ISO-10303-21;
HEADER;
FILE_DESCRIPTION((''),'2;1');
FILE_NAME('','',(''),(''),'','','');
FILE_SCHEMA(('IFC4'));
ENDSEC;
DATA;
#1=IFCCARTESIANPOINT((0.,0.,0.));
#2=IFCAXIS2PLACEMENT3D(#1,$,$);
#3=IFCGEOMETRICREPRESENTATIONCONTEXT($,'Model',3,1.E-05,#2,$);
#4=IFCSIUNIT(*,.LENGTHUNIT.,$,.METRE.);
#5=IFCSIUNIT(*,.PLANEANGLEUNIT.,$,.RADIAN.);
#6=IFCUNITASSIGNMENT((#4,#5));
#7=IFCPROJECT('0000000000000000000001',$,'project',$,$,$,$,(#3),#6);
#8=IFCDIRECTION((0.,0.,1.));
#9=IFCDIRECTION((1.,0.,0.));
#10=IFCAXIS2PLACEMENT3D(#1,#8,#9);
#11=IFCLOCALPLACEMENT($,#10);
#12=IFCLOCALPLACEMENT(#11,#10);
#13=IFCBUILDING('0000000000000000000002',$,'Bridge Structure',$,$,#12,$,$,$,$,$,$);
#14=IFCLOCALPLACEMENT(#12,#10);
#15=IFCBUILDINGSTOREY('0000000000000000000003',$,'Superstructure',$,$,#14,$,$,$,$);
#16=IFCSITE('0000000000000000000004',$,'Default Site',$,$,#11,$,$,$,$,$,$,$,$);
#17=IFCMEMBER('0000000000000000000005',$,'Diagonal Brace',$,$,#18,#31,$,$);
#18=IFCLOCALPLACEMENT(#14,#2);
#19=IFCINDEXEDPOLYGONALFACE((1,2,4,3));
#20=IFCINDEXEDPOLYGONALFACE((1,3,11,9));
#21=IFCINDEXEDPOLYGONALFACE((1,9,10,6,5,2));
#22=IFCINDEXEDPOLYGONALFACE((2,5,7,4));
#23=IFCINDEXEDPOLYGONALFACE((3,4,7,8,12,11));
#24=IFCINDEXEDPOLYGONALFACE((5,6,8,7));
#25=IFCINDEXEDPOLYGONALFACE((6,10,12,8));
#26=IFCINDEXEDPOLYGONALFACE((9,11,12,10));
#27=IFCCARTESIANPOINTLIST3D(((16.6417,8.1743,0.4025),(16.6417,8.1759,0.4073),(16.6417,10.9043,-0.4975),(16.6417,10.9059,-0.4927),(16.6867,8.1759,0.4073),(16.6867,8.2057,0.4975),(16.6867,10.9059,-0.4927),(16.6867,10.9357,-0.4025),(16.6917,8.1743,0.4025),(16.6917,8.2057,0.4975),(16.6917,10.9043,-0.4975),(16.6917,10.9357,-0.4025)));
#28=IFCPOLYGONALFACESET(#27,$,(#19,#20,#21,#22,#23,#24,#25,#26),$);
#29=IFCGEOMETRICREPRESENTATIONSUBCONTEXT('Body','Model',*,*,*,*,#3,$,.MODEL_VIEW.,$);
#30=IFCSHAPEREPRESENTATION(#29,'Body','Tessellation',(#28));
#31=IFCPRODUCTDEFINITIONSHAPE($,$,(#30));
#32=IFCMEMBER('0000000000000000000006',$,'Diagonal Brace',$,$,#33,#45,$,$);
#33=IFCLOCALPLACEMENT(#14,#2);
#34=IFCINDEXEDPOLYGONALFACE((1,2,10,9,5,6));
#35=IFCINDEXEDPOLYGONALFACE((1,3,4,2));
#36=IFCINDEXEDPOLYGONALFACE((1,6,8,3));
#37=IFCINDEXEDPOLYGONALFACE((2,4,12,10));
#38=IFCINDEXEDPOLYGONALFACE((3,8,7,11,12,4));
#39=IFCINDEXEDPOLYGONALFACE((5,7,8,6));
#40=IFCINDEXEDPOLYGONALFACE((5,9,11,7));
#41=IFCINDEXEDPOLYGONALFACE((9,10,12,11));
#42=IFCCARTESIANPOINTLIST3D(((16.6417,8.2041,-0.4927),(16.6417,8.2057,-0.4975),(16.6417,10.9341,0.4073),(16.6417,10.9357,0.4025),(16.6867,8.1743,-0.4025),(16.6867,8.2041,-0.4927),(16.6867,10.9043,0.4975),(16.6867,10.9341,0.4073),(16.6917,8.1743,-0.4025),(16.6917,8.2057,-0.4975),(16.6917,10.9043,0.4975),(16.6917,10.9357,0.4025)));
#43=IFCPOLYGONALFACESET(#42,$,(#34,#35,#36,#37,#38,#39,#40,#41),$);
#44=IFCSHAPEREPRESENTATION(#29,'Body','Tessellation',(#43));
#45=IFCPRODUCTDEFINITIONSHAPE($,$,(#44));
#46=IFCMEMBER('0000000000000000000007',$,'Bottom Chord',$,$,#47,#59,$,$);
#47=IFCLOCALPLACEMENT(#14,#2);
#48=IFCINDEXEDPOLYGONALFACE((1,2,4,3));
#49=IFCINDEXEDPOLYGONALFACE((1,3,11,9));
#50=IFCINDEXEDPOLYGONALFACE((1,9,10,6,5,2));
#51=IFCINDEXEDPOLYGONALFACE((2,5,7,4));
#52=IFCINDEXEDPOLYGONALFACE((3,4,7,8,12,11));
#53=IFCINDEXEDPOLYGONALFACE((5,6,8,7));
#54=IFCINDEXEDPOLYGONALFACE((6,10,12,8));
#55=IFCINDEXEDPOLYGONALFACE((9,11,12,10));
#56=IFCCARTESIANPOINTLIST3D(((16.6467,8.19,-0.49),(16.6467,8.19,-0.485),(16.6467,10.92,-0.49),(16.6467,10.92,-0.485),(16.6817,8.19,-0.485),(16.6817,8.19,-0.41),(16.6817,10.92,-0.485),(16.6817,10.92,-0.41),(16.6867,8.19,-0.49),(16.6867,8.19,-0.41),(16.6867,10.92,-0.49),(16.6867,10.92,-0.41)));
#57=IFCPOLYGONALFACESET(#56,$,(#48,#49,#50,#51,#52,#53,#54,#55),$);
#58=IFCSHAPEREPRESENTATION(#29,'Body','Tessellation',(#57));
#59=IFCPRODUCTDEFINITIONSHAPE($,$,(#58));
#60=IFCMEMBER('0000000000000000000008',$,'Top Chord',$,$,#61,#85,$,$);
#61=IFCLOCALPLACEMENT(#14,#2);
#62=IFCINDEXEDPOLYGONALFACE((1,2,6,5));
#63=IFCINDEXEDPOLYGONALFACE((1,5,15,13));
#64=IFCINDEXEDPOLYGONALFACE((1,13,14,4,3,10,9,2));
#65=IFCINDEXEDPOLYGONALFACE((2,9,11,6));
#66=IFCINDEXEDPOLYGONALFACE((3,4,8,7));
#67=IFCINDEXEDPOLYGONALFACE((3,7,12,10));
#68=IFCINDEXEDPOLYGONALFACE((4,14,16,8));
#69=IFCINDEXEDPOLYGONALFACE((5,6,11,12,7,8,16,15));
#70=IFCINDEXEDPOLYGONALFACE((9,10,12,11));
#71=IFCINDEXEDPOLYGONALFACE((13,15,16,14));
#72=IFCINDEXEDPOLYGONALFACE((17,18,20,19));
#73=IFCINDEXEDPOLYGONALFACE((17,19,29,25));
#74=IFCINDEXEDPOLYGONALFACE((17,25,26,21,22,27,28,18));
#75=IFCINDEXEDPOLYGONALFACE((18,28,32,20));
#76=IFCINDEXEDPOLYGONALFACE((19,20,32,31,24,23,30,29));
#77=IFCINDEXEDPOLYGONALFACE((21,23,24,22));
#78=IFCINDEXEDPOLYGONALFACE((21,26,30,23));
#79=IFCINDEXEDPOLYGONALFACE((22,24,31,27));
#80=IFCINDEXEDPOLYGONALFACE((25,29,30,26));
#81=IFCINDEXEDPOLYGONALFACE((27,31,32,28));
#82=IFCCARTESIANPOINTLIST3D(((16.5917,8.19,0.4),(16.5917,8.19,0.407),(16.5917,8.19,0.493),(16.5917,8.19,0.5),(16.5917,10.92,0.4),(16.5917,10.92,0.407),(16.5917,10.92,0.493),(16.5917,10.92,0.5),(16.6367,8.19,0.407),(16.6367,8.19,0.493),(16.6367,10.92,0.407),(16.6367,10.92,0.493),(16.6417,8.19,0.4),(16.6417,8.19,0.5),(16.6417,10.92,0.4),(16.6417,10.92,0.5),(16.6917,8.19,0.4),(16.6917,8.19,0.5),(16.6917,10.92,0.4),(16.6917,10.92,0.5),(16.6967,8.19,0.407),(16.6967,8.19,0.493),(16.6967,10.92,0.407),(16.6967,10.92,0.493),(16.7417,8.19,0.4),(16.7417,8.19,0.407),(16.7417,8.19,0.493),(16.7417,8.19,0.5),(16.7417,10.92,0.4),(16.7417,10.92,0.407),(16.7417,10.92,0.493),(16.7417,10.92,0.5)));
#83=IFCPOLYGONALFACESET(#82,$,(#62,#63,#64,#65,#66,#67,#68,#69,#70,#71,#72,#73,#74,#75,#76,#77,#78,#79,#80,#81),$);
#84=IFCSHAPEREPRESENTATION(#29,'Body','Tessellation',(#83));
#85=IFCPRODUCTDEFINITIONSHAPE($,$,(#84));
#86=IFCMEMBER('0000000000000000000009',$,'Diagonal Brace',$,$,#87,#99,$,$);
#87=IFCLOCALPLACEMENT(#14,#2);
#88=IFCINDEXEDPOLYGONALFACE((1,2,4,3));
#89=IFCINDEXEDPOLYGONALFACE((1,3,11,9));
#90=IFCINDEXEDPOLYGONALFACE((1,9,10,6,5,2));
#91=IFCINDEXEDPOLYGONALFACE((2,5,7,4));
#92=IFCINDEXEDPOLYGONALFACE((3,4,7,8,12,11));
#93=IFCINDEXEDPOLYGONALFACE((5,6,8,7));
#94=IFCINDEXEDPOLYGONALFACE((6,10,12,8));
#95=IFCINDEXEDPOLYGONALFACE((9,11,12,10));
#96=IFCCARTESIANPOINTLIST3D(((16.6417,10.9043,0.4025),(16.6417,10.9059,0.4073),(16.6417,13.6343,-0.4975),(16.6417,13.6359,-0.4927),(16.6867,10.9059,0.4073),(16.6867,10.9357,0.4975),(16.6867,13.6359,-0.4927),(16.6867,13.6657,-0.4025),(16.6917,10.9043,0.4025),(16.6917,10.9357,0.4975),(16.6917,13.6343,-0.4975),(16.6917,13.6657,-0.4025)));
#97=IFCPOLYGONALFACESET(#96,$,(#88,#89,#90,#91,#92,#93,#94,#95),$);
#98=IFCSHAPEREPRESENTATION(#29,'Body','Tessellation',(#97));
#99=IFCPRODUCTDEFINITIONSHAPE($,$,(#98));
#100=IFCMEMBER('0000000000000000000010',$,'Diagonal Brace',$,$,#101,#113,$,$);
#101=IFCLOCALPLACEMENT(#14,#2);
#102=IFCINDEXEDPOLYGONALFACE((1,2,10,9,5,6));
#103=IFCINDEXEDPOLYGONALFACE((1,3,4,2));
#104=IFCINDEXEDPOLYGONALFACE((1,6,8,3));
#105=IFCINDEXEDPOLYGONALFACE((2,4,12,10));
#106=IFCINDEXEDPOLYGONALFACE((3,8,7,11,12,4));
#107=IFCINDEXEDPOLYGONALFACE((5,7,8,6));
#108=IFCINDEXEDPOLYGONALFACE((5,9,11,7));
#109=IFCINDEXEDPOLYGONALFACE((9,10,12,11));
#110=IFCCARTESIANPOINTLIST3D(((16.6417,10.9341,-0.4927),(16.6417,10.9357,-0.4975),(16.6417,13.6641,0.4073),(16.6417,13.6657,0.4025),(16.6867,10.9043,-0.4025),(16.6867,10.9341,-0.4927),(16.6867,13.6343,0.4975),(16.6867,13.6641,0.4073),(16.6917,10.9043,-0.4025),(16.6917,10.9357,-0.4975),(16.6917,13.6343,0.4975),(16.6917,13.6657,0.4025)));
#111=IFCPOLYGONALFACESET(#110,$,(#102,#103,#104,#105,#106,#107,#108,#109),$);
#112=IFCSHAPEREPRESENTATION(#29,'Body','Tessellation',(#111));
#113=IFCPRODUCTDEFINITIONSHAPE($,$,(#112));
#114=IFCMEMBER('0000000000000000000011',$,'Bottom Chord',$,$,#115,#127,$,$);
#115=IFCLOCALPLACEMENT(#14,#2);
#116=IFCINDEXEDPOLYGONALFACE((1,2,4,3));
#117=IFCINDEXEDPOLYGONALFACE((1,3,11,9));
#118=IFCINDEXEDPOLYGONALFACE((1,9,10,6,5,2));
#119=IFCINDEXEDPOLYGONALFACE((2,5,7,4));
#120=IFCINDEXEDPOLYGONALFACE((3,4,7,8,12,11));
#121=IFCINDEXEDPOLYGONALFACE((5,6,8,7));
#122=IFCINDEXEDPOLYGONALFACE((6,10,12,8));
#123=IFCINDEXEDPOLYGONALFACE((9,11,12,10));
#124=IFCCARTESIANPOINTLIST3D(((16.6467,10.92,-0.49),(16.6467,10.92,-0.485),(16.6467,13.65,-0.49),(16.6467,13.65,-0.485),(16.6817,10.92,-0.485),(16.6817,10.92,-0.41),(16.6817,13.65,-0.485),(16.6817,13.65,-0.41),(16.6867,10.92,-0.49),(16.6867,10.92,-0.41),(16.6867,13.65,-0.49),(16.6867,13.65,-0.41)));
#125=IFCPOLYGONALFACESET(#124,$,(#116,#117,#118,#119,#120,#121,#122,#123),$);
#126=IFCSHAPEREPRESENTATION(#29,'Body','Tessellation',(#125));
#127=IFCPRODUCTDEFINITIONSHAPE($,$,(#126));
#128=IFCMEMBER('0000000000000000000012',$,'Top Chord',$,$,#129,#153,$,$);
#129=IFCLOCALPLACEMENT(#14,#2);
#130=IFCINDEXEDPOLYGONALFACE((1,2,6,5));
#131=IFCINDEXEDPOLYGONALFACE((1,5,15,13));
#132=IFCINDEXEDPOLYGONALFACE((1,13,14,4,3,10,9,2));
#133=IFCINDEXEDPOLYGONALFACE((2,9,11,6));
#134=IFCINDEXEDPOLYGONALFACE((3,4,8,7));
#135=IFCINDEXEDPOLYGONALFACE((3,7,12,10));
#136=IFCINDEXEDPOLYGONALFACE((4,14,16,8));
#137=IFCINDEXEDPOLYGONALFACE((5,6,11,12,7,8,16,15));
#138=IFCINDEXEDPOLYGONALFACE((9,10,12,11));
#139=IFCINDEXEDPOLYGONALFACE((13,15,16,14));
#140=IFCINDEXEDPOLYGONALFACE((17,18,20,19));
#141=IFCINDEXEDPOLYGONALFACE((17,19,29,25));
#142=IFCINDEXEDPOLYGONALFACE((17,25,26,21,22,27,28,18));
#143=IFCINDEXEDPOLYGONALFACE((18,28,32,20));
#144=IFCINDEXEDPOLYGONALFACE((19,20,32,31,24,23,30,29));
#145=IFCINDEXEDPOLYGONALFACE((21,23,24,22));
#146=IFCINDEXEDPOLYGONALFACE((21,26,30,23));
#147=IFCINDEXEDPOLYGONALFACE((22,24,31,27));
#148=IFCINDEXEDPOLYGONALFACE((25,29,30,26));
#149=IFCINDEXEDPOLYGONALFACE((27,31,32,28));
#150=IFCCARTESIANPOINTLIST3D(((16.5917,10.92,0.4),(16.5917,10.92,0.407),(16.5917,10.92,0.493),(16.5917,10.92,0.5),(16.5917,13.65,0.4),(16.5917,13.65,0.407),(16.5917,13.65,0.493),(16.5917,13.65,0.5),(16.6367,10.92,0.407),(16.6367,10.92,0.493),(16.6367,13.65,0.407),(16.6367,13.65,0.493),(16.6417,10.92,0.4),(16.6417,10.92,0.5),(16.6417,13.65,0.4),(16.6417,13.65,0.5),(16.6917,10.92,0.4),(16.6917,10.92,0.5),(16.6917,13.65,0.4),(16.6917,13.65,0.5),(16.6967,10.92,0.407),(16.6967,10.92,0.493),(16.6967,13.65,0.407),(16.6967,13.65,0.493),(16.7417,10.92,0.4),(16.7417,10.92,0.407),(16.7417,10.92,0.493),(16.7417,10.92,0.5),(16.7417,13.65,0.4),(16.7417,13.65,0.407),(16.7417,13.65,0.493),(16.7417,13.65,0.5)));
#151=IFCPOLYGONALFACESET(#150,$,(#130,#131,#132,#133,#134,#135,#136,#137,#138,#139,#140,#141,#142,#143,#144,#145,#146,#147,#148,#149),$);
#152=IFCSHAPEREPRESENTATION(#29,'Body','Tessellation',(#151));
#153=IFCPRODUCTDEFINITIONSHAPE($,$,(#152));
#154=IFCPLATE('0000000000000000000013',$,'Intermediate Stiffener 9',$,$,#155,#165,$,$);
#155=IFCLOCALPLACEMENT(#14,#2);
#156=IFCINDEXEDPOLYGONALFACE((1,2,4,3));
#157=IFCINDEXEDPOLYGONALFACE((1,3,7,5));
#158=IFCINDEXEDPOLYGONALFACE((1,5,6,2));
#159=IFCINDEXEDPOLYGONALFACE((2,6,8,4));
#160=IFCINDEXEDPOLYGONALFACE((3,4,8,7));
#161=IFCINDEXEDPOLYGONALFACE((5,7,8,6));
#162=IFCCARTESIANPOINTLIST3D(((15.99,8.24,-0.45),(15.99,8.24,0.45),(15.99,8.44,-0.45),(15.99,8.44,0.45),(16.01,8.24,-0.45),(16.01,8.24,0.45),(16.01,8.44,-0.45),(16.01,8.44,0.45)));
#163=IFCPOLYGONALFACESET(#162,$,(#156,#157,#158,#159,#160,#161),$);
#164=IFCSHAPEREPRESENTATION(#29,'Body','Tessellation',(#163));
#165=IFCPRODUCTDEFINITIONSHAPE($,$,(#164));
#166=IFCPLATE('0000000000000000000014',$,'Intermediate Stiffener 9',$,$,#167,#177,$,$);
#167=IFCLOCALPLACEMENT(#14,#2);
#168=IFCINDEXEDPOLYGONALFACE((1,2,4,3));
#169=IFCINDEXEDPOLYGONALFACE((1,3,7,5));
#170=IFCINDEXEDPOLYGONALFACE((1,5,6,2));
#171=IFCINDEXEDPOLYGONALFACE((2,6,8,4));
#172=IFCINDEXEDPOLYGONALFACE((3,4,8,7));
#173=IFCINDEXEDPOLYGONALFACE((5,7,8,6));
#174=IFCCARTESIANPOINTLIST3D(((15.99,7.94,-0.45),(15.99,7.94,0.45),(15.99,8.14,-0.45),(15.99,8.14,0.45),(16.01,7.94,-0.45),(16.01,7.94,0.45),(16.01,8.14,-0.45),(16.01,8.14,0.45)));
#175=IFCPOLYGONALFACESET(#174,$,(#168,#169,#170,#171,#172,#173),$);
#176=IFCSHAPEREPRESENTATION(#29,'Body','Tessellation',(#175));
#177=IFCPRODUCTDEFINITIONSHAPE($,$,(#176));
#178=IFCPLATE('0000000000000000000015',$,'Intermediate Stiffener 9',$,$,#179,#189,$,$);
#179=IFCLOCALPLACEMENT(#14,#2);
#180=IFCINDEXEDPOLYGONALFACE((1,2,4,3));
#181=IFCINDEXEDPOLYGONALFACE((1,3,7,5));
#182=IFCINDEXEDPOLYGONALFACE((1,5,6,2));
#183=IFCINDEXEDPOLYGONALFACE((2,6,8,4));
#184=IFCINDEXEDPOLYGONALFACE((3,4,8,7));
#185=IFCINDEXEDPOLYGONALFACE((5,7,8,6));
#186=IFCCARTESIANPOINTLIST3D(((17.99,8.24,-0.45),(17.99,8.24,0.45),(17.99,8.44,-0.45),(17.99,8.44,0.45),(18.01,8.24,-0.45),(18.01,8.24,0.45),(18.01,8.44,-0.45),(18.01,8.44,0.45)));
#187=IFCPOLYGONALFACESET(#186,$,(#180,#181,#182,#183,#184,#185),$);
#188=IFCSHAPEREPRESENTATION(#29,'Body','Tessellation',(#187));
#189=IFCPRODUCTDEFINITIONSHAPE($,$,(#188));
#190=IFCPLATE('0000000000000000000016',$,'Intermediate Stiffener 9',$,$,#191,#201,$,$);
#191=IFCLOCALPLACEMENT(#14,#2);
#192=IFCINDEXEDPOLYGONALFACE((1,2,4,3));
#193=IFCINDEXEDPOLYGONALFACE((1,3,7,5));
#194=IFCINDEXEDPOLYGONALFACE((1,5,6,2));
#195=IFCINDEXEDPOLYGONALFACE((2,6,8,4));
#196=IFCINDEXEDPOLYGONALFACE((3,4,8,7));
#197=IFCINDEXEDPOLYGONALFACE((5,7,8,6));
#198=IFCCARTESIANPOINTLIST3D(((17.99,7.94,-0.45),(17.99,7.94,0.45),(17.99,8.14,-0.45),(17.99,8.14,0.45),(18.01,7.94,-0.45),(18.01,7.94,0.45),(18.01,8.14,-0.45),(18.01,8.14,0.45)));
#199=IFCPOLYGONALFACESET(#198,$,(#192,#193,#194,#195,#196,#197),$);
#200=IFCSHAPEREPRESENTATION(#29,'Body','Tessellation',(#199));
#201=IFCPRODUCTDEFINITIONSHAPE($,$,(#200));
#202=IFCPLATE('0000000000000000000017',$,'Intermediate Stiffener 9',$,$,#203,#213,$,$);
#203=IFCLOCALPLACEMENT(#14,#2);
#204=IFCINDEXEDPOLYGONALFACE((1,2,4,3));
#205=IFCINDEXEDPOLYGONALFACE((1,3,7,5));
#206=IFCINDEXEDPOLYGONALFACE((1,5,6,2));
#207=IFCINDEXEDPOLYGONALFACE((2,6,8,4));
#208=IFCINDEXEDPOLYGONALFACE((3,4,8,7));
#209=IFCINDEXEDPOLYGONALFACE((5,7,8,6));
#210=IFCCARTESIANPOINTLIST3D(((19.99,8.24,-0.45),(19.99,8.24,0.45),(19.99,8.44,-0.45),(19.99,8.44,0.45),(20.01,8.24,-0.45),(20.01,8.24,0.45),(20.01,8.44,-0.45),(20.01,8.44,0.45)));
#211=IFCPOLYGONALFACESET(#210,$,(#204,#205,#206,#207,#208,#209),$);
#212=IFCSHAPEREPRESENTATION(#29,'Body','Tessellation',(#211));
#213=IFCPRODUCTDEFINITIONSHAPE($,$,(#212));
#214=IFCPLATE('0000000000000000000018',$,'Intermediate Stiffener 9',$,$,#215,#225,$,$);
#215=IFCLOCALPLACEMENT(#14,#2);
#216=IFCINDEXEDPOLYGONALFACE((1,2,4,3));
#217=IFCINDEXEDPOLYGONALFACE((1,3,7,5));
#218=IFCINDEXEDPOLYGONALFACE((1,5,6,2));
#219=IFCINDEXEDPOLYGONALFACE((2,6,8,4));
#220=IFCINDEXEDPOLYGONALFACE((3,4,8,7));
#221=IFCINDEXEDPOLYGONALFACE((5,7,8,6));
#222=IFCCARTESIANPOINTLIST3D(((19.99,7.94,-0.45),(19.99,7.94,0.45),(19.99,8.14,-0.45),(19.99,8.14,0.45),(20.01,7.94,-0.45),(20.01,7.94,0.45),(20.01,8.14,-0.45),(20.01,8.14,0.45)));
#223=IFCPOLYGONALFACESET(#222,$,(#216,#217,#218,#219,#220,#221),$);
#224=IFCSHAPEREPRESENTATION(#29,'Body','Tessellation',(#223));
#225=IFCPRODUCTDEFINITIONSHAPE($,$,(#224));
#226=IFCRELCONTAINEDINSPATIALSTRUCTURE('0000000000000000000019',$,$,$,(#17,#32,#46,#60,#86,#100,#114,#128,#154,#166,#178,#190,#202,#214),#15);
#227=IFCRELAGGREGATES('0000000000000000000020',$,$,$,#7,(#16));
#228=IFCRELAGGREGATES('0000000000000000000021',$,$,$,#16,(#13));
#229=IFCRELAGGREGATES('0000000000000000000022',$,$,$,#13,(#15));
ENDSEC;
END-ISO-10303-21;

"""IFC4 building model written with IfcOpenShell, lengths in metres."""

from ifc_helpers import new_model, si_unit, frame, origin, origin_with_axes, origin_2d_with_axis, place, context, subcontext, project, spatial, polyline, rectangle, l_section, outline, composite_profile, extrude, element, save


model = new_model("IFC4")

# Units and contexts
model_context = context("Model", 3, precision=1e-05, world=origin())
body_context = subcontext(model_context, "Body", "Model", "MODEL_VIEW")
ifc_project = project(units=[si_unit("LENGTHUNIT", "METRE"), si_unit("PLANEANGLEUNIT", "RADIAN")], contexts=[model_context])

# Site, building, storey
site_placement = place(None, origin_with_axes())
site = spatial("IfcSite", under=ifc_project, at=site_placement, Name="Default Site")
building_placement = place(site_placement, origin_with_axes())
building = spatial("IfcBuilding", under=site, at=building_placement, Name="Bridge Structure")
storey_placement = place(building_placement, origin_with_axes())
storey = spatial("IfcBuildingStorey", under=building, at=storey_placement, Name="Superstructure")

# Members
for number, where, z_axis, x_axis, name in (
    (1, (16.6667, 8.19, 0.45), (0.0, 0.949722, -0.313095), (-1.0, 0.0, 0.0), "Diagonal Brace"),
    (2, (16.6667, 8.19, -0.45), (0.0, 0.949722, 0.313095), (-1.0, 0.0, 0.0), "Diagonal Brace"),
):
    element("IfcMember", number, at=place(storey_placement, frame(where, z_axis=z_axis, x_axis=x_axis)), inside=storey, Name=name, context=body_context, shape_type="SweptSolid", body=[
        extrude(l_section(Depth=0.1, Width=0.05, Thickness=0.005, at=origin_2d_with_axis()), origin_with_axes(), (0.0, 0.0, 1.0), 2.8745),
    ])
member_1_placement = place(storey_placement, frame((16.6667, 8.19, -0.45), z_axis=(0.0, 1.0, 0.0), x_axis=(-1.0, 0.0, 0.0)))
element("IfcMember", 3, at=member_1_placement, inside=storey, Name="Bottom Chord", context=body_context, shape_type="SweptSolid", body=[
    extrude(l_section(Depth=0.08, Width=0.04, Thickness=0.005, at=origin_2d_with_axis()), origin_with_axes(), (0.0, 0.0, 1.0), 2.73),
])
member_2_placement = place(storey_placement, frame((16.6667, 8.19, 0.45), z_axis=(0.0, 1.0, 0.0), x_axis=(-1.0, 0.0, 0.0)))
element("IfcMember", 4, at=member_2_placement, inside=storey, Name="Top Chord", context=body_context, shape_type="SweptSolid", body=[
    extrude(composite_profile([outline(polyline([(-0.025, -0.05), (-0.025, 0.05), (-0.075, 0.05), (-0.075, 0.043), (-0.03, 0.043), (-0.03, -0.043), (-0.075, -0.043), (-0.075, -0.05), (-0.025, -0.05)])), outline(polyline([(0.025, -0.05), (0.075, -0.05), (0.075, -0.043), (0.03, -0.043), (0.03, 0.043), (0.075, 0.043), (0.075, 0.05), (0.025, 0.05), (0.025, -0.05)]))]), origin_with_axes(), (0.0, 0.0, 1.0), 2.73),
])
for number, where, z_axis, x_axis, name in (
    (5, (16.6667, 10.92, 0.45), (0.0, 0.949722, -0.313095), (-1.0, 0.0, 0.0), "Diagonal Brace"),
    (6, (16.6667, 10.92, -0.45), (0.0, 0.949722, 0.313095), (-1.0, 0.0, 0.0), "Diagonal Brace"),
):
    element("IfcMember", number, at=place(storey_placement, frame(where, z_axis=z_axis, x_axis=x_axis)), inside=storey, Name=name, context=body_context, shape_type="SweptSolid", body=[
        extrude(l_section(Depth=0.1, Width=0.05, Thickness=0.005, at=origin_2d_with_axis()), origin_with_axes(), (0.0, 0.0, 1.0), 2.8745),
    ])
member_3_placement = place(storey_placement, frame((16.6667, 10.92, -0.45), z_axis=(0.0, 1.0, 0.0), x_axis=(-1.0, 0.0, 0.0)))
element("IfcMember", 7, at=member_3_placement, inside=storey, Name="Bottom Chord", context=body_context, shape_type="SweptSolid", body=[
    extrude(l_section(Depth=0.08, Width=0.04, Thickness=0.005, at=origin_2d_with_axis()), origin_with_axes(), (0.0, 0.0, 1.0), 2.73),
])
member_4_placement = place(storey_placement, frame((16.6667, 10.92, 0.45), z_axis=(0.0, 1.0, 0.0), x_axis=(-1.0, 0.0, 0.0)))
element("IfcMember", 8, at=member_4_placement, inside=storey, Name="Top Chord", context=body_context, shape_type="SweptSolid", body=[
    extrude(composite_profile([outline(polyline([(-0.025, -0.05), (-0.025, 0.05), (-0.075, 0.05), (-0.075, 0.043), (-0.03, 0.043), (-0.03, -0.043), (-0.075, -0.043), (-0.075, -0.05), (-0.025, -0.05)])), outline(polyline([(0.025, -0.05), (0.075, -0.05), (0.075, -0.043), (0.03, -0.043), (0.03, 0.043), (0.075, 0.043), (0.075, 0.05), (0.025, 0.05), (0.025, -0.05)]))]), origin_with_axes(), (0.0, 0.0, 1.0), 2.73),
])

# Plates
for number, where, z_axis, x_axis, name in (
    (9, (16.0, 8.34, -0.45), (0.0, 0.0, 1.0), (1.0, 0.0, 0.0), "Intermediate Stiffener 9"),
    (10, (16.0, 8.04, -0.45), (0.0, 0.0, 1.0), (1.0, 0.0, 0.0), "Intermediate Stiffener 9"),
    (11, (18.0, 8.34, -0.45), (0.0, 0.0, 1.0), (1.0, 0.0, 0.0), "Intermediate Stiffener 9"),
    (12, (18.0, 8.04, -0.45), (0.0, 0.0, 1.0), (1.0, 0.0, 0.0), "Intermediate Stiffener 9"),
    (13, (20.0, 8.34, -0.45), (0.0, 0.0, 1.0), (1.0, 0.0, 0.0), "Intermediate Stiffener 9"),
    (14, (20.0, 8.04, -0.45), (0.0, 0.0, 1.0), (1.0, 0.0, 0.0), "Intermediate Stiffener 9"),
):
    element("IfcPlate", number, at=place(storey_placement, frame(where, z_axis=z_axis, x_axis=x_axis)), inside=storey, Name=name, context=body_context, shape_type="SweptSolid", body=[
        extrude(rectangle(XDim=0.02, YDim=0.2, at=origin_2d_with_axis()), origin_with_axes(), (0.0, 0.0, 1.0), 0.9),
    ])

save(model, "model.ifc")
